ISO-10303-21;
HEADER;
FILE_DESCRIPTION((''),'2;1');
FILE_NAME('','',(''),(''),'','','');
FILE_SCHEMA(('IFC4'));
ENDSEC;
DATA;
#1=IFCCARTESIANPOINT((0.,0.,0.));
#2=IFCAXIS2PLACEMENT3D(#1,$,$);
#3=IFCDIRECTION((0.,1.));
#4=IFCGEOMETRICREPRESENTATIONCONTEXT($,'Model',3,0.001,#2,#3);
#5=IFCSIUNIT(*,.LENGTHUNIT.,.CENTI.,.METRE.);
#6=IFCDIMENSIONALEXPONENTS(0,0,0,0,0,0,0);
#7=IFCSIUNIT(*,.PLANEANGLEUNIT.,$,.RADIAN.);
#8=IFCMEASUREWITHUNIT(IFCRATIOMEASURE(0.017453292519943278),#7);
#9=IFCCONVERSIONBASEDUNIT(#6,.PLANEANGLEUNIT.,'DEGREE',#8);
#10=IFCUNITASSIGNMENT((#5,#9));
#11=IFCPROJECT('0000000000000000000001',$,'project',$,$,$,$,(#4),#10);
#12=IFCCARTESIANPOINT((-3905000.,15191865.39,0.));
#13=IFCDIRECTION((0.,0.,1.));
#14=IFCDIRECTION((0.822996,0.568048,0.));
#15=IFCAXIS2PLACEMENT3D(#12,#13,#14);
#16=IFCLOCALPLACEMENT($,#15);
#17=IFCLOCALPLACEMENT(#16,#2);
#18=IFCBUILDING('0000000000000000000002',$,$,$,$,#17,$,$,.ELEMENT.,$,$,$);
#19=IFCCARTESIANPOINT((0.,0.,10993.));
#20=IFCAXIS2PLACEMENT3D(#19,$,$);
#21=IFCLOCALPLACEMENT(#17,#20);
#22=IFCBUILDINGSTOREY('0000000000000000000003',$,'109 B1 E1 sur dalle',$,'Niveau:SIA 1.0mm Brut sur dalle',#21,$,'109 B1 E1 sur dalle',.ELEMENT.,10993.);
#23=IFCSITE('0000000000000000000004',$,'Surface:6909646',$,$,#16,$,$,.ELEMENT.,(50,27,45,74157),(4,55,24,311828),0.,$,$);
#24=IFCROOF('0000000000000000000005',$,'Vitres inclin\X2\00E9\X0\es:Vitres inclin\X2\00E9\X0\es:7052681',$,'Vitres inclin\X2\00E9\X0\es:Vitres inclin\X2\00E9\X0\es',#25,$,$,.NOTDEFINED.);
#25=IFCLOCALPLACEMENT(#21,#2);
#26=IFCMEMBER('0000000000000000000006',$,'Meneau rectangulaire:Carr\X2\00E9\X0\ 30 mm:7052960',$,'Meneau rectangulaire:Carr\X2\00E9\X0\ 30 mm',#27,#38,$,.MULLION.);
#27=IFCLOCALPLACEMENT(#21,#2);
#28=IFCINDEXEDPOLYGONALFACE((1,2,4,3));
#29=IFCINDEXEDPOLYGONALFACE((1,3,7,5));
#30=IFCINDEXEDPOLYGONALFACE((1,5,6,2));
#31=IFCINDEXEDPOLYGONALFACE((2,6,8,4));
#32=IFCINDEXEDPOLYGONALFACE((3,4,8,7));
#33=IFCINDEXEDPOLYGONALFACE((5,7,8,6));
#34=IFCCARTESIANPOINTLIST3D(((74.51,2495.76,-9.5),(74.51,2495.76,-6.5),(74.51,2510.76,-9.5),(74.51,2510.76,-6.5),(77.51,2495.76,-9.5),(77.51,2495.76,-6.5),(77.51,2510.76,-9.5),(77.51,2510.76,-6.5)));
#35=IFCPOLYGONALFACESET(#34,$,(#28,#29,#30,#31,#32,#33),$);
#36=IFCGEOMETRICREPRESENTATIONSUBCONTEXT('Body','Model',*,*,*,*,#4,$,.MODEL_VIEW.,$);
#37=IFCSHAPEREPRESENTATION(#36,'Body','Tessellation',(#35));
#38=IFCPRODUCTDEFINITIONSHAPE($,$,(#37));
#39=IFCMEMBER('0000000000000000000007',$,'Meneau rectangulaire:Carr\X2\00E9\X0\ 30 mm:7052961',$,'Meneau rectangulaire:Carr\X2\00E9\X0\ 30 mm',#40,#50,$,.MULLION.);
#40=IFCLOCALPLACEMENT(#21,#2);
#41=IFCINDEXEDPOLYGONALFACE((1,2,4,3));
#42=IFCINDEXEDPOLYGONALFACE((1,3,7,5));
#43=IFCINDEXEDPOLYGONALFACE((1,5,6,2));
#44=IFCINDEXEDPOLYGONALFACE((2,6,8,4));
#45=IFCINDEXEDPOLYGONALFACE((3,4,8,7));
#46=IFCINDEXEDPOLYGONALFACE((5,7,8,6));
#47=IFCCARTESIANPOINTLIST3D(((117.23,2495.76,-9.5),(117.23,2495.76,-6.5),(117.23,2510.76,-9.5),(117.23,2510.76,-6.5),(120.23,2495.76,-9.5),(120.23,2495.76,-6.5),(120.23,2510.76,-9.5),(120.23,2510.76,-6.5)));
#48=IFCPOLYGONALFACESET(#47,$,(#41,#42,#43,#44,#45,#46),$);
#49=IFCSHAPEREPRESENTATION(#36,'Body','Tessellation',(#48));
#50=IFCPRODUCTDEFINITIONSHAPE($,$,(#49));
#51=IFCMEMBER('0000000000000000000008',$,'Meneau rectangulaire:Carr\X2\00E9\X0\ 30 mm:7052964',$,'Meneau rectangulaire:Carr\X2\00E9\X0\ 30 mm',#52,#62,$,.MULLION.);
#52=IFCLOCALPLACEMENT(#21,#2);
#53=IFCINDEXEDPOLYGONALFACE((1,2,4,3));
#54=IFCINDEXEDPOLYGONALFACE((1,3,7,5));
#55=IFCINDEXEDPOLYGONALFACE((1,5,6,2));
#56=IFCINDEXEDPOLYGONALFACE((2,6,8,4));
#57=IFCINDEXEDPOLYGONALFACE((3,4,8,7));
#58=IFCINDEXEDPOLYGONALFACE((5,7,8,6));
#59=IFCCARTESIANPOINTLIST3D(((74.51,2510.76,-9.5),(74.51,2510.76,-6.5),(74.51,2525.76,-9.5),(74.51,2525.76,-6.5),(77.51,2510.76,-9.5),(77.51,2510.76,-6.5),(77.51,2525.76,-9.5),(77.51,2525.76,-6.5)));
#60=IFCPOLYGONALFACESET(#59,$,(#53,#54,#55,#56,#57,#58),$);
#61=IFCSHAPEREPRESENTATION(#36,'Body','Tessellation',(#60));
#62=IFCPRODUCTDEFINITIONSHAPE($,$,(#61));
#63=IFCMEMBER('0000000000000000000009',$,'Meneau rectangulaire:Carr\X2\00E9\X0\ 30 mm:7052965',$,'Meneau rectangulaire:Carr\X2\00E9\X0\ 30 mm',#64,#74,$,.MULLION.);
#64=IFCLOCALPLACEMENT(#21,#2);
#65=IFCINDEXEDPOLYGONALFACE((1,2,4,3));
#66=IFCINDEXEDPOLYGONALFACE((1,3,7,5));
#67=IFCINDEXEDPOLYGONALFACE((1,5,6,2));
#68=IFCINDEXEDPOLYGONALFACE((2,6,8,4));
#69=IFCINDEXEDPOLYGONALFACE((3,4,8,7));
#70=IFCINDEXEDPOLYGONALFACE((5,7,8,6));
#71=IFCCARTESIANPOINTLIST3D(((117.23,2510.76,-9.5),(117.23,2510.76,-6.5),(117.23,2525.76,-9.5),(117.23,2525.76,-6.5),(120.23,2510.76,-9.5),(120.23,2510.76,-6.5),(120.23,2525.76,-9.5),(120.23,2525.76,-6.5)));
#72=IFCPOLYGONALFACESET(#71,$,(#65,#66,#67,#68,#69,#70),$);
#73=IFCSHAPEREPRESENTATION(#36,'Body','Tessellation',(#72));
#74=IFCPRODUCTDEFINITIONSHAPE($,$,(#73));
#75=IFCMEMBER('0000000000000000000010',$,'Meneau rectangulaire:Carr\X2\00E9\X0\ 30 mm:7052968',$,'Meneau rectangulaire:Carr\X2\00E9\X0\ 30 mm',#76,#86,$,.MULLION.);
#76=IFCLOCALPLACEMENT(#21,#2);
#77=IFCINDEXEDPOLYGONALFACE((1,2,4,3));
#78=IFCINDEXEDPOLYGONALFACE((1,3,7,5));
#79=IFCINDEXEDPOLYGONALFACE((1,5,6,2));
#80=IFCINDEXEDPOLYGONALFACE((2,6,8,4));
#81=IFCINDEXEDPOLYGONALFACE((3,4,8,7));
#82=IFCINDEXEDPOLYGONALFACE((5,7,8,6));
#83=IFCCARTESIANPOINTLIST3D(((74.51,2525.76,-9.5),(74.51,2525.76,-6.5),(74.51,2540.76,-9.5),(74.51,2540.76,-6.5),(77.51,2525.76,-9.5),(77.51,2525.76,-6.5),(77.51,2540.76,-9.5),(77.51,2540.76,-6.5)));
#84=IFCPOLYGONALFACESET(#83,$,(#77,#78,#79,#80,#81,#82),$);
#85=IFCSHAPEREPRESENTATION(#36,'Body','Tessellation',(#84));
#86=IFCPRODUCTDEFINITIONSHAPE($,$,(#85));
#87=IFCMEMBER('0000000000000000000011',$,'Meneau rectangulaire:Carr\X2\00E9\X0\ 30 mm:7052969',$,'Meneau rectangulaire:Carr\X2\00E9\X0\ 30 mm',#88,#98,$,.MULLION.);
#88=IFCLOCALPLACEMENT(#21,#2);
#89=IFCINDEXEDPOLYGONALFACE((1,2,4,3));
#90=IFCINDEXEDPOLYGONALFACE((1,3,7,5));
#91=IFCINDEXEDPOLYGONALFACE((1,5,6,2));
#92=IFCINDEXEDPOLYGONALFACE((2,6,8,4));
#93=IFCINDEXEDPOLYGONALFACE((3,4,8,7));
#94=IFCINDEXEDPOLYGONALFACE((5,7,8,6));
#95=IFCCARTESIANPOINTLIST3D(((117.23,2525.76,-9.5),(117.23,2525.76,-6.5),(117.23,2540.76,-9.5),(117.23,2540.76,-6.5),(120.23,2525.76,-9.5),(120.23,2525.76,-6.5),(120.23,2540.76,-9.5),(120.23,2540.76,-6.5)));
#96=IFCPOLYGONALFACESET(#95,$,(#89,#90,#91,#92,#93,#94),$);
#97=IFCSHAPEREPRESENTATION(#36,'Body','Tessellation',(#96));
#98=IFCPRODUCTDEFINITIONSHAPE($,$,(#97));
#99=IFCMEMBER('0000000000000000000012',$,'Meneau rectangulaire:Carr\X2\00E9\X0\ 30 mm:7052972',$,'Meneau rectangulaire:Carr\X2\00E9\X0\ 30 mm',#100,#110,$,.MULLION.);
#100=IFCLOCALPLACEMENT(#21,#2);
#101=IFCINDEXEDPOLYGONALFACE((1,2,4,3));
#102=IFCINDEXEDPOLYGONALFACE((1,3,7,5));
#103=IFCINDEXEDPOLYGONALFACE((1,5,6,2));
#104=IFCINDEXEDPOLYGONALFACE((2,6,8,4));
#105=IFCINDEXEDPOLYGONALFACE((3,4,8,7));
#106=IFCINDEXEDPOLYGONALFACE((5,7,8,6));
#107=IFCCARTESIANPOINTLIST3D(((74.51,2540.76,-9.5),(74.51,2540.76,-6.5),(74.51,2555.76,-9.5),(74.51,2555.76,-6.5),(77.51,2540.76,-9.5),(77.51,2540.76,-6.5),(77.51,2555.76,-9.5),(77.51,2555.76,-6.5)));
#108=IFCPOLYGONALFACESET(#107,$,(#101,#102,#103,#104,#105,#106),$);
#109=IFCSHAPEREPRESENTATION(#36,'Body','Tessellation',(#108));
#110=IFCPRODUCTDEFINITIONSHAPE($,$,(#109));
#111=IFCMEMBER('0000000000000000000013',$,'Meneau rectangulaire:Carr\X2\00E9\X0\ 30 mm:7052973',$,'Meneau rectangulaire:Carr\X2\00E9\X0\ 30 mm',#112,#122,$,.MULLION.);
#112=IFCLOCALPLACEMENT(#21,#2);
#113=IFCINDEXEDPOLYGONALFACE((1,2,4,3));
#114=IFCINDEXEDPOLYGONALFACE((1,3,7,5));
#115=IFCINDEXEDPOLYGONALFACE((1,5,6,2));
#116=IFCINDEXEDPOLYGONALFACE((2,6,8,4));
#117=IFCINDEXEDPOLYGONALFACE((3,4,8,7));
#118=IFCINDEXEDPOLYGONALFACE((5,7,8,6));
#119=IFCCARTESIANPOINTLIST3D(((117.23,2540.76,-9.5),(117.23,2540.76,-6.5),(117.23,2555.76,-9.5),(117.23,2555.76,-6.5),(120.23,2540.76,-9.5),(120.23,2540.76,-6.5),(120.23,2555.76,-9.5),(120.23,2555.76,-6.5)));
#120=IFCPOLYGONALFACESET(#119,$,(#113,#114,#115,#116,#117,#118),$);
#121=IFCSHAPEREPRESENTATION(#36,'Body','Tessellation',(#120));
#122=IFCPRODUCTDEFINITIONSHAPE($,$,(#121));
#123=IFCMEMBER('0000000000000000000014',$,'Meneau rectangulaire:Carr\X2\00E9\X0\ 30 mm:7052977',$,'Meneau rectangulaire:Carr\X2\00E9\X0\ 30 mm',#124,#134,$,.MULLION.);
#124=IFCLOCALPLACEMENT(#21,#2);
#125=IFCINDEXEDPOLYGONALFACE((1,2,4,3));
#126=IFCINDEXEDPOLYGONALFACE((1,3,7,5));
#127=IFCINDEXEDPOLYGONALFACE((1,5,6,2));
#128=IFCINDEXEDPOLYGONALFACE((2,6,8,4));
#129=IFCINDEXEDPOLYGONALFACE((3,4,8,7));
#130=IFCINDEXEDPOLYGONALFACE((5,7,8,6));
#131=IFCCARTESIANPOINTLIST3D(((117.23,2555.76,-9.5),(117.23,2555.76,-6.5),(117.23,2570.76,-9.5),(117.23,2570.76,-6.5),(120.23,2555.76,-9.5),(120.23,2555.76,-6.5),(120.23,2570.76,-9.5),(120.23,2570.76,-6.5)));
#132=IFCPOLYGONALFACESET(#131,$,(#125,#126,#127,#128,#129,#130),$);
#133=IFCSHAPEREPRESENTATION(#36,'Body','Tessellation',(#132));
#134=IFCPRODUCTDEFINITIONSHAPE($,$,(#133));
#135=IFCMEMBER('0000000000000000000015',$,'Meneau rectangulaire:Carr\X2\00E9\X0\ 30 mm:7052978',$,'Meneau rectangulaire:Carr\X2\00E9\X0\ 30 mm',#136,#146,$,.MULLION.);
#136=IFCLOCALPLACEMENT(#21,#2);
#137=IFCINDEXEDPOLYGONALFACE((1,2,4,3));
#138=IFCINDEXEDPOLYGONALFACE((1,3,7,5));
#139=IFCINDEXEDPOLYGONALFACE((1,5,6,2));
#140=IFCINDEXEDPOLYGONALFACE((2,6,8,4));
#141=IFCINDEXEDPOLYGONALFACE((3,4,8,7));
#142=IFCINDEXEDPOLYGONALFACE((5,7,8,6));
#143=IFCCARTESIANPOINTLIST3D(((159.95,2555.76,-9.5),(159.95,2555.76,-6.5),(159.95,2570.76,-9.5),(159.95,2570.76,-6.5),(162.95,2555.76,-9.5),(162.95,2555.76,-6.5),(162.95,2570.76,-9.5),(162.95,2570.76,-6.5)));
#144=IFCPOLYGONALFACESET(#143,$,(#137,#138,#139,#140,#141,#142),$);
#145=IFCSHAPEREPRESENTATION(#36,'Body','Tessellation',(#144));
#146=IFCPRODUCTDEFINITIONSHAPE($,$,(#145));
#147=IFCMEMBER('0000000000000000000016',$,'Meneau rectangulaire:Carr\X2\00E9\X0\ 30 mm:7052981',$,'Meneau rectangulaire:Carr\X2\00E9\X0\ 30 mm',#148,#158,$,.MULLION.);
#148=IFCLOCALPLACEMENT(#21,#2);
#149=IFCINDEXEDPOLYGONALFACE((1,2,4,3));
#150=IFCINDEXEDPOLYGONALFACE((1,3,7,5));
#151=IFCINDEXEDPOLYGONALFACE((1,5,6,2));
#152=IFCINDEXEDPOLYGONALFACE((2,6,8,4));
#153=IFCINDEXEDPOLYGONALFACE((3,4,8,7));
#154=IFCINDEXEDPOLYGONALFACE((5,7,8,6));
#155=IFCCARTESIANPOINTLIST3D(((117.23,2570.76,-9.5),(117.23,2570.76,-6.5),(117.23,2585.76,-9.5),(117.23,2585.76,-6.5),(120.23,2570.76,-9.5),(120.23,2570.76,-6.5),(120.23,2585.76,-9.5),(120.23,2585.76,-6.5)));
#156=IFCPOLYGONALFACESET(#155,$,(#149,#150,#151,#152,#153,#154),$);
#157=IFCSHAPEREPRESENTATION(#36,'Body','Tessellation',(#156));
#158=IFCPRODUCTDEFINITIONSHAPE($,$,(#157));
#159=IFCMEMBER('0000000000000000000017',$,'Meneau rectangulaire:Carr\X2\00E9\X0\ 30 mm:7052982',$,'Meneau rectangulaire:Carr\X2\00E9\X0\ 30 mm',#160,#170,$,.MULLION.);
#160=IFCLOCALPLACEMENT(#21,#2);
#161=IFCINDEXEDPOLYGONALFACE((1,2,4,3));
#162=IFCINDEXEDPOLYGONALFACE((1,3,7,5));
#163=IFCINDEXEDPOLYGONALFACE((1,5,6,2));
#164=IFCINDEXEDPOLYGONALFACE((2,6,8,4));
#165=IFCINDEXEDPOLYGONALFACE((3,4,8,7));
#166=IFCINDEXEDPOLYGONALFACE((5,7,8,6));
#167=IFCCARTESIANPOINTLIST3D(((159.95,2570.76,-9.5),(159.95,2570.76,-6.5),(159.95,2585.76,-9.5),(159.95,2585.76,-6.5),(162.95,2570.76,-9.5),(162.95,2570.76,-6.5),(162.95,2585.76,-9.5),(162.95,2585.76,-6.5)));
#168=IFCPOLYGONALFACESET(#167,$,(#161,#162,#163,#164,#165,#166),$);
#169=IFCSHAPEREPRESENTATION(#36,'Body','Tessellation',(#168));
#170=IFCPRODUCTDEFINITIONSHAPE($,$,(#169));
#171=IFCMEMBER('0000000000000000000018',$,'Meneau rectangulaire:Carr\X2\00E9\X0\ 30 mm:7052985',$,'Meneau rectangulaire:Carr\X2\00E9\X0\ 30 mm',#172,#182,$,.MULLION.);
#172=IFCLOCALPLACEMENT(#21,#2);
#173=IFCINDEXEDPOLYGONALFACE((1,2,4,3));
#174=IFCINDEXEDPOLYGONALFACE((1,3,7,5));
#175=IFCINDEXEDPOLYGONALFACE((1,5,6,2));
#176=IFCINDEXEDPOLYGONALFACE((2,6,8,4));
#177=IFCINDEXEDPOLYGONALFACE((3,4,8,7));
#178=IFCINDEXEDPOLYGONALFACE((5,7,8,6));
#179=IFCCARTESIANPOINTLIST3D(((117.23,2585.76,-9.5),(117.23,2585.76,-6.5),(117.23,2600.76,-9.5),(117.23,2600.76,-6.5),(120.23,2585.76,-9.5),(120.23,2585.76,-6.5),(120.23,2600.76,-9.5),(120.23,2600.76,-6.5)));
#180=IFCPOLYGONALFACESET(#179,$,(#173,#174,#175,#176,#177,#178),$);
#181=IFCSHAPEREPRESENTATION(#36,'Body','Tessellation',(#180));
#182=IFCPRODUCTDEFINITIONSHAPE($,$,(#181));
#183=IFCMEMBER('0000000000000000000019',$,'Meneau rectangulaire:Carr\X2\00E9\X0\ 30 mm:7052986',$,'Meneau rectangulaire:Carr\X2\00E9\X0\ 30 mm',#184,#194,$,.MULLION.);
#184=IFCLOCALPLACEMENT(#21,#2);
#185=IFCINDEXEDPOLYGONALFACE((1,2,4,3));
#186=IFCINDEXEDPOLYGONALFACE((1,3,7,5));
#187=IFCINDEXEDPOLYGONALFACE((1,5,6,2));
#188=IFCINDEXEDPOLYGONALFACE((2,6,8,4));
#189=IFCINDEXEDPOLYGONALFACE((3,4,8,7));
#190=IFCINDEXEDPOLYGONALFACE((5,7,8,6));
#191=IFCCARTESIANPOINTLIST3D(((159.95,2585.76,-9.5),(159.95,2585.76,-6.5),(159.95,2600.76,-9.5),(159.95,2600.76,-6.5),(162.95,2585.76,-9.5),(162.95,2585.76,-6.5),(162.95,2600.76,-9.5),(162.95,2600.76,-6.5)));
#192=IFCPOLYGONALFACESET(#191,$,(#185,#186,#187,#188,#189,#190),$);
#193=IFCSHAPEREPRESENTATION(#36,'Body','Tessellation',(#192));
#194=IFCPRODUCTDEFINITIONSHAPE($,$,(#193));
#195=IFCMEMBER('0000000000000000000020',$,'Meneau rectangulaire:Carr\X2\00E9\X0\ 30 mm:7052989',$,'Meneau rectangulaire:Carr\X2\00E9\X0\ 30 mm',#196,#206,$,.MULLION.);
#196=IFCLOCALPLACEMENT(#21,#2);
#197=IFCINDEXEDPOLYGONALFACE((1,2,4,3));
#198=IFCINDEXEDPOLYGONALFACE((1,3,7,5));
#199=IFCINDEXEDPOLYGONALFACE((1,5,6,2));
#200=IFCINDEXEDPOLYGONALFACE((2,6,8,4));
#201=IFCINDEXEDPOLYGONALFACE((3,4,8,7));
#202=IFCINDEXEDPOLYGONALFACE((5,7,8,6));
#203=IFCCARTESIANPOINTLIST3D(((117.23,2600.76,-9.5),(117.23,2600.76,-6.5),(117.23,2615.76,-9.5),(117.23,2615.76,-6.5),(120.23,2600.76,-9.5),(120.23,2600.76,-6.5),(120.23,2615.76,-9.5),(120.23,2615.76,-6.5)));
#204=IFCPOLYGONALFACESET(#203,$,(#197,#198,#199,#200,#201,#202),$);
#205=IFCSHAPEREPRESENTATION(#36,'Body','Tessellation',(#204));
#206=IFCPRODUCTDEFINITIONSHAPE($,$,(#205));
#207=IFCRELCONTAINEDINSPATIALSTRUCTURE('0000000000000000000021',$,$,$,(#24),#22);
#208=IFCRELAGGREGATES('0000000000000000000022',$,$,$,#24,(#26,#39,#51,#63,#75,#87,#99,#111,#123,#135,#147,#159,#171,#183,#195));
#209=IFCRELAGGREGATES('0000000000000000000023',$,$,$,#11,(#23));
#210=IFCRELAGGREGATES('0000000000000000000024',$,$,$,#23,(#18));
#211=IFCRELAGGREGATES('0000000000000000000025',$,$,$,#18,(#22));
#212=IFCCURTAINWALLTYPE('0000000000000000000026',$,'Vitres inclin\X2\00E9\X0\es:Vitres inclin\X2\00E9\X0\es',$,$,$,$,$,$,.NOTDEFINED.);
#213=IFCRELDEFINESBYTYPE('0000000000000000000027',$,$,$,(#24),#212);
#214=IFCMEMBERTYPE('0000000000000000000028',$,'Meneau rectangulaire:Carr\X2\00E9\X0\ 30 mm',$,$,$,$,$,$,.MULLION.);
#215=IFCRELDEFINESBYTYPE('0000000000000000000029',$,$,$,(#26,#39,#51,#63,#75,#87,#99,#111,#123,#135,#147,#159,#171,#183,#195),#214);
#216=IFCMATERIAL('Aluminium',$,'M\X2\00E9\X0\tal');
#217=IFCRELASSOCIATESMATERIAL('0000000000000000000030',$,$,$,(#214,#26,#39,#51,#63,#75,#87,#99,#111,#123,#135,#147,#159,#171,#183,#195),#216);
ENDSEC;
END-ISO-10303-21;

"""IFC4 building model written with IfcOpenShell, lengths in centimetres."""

from ifc_helpers import new_model, entity, si_unit, converted_unit, direction, frame, origin, place, context, subcontext, project, spatial, indexed_curve, outline, extrude, source, transform, mapped, material, type_object, type_shapes, element, aggregate, save


model = new_model("IFC4")

# Units and contexts
model_context = context("Model", 3, precision=0.001, world=origin(), true_north=direction((0.0, 1.0)))
body_context = subcontext(model_context, "Body", "Model", "MODEL_VIEW")
ifc_project = project(units=[si_unit("LENGTHUNIT", "METRE", prefix="CENTI"), converted_unit("PLANEANGLEUNIT", "DEGREE", entity("IfcRatioMeasure", 0.017453292519943278), si_unit("PLANEANGLEUNIT", "RADIAN"), dimensions=[0, 0, 0, 0, 0, 0, 0])], contexts=[model_context])

# Site, building, storey
site_placement = place(None, frame((-3905000.0, 15191865.39, 0.0), z_axis=(0.0, 0.0, 1.0), x_axis=(0.822996, 0.568048, 0.0)))
site = spatial("IfcSite", under=ifc_project, at=site_placement, Name="Surface:6909646", CompositionType="ELEMENT", RefLatitude=(50, 27, 45, 74157), RefLongitude=(4, 55, 24, 311828), RefElevation=0.0)
building_placement = place(site_placement, origin())
building = spatial("IfcBuilding", under=site, at=building_placement, CompositionType="ELEMENT")
storey_placement = place(building_placement, frame((0.0, 0.0, 10993.0)))
storey = spatial("IfcBuildingStorey", under=building, at=storey_placement, Name="109 B1 E1 sur dalle", ObjectType="Niveau:SIA 1.0mm Brut sur dalle", LongName="109 B1 E1 sur dalle", CompositionType="ELEMENT", Elevation=10993.0)

# Roof, members
curtain_wall_type = type_object("IfcCurtainWallType", Name="Vitres inclinées:Vitres inclinées", PredefinedType="NOTDEFINED")
roof_placement = place(storey_placement, frame((0.0, 0.0, -10993.0)))
roof = element("IfcRoof", 1, at=roof_placement, inside=storey, type_object=curtain_wall_type, Name="Vitres inclinées:Vitres inclinées:7052681", ObjectType="Vitres inclinées:Vitres inclinées", PredefinedType="NOTDEFINED")
ifc_material = material(Name="Aluminium", Category="Métal")
member_type_1 = type_object("IfcMemberType", Name="Meneau rectangulaire:Carré 30 mm", PredefinedType="MULLION", material=ifc_material)
shared_shape_1 = source(origin(), body_context, "Body", "SweptSolid", [
    extrude(outline(indexed_curve([(-1.5, -1.5), (1.5, -1.5), (1.5, 1.5), (-1.5, 1.5), (-1.5, -1.5)], self_intersect=False)), frame((0.0, 0.0, -15.0), z_axis=(0.0, 0.0, 1.0), x_axis=(0.0, -1.0, 0.0)), (0.0, 0.0, 1.0), 15.0),
])
type_shapes(member_type_1, [shared_shape_1])
member_1_placement = place(roof_placement, frame((76.01, 2510.76, 10985.0), z_axis=(0.0, 1.0, 0.0), x_axis=(1.0, 0.0, 0.0)))
member_1 = element("IfcMember", 2, at=member_1_placement, type_object=member_type_1, material=ifc_material, Name="Meneau rectangulaire:Carré 30 mm:7052960", ObjectType="Meneau rectangulaire:Carré 30 mm", PredefinedType="MULLION", context=body_context, shape_type="MappedRepresentation", body=[
    mapped(shared_shape_1, transform((0.0, 0.0, 0.0), scale=1.0)),
])
member_2_placement = place(roof_placement, frame((118.73, 2510.76, 10985.0), z_axis=(0.0, 1.0, 0.0), x_axis=(1.0, 0.0, 0.0)))
member_2 = element("IfcMember", 3, at=member_2_placement, type_object=member_type_1, material=ifc_material, Name="Meneau rectangulaire:Carré 30 mm:7052961", ObjectType="Meneau rectangulaire:Carré 30 mm", PredefinedType="MULLION", context=body_context, shape_type="MappedRepresentation", body=[
    mapped(shared_shape_1, transform((0.0, 0.0, 0.0), scale=1.0)),
])
member_3_placement = place(roof_placement, frame((76.01, 2525.76, 10985.0), z_axis=(0.0, 1.0, 0.0), x_axis=(1.0, 0.0, 0.0)))
member_3 = element("IfcMember", 4, at=member_3_placement, type_object=member_type_1, material=ifc_material, Name="Meneau rectangulaire:Carré 30 mm:7052964", ObjectType="Meneau rectangulaire:Carré 30 mm", PredefinedType="MULLION", context=body_context, shape_type="MappedRepresentation", body=[
    mapped(shared_shape_1, transform((0.0, 0.0, 0.0), scale=1.0)),
])
member_4_placement = place(roof_placement, frame((118.73, 2525.76, 10985.0), z_axis=(0.0, 1.0, 0.0), x_axis=(1.0, 0.0, 0.0)))
member_4 = element("IfcMember", 5, at=member_4_placement, type_object=member_type_1, material=ifc_material, Name="Meneau rectangulaire:Carré 30 mm:7052965", ObjectType="Meneau rectangulaire:Carré 30 mm", PredefinedType="MULLION", context=body_context, shape_type="MappedRepresentation", body=[
    mapped(shared_shape_1, transform((0.0, 0.0, 0.0), scale=1.0)),
])
member_5_placement = place(roof_placement, frame((76.01, 2540.76, 10985.0), z_axis=(0.0, 1.0, 0.0), x_axis=(1.0, 0.0, 0.0)))
member_5 = element("IfcMember", 6, at=member_5_placement, type_object=member_type_1, material=ifc_material, Name="Meneau rectangulaire:Carré 30 mm:7052968", ObjectType="Meneau rectangulaire:Carré 30 mm", PredefinedType="MULLION", context=body_context, shape_type="MappedRepresentation", body=[
    mapped(shared_shape_1, transform((0.0, 0.0, 0.0), scale=1.0)),
])
member_6_placement = place(roof_placement, frame((118.73, 2540.76, 10985.0), z_axis=(0.0, 1.0, 0.0), x_axis=(1.0, 0.0, 0.0)))
member_6 = element("IfcMember", 7, at=member_6_placement, type_object=member_type_1, material=ifc_material, Name="Meneau rectangulaire:Carré 30 mm:7052969", ObjectType="Meneau rectangulaire:Carré 30 mm", PredefinedType="MULLION", context=body_context, shape_type="MappedRepresentation", body=[
    mapped(shared_shape_1, transform((0.0, 0.0, 0.0), scale=1.0)),
])
member_7_placement = place(roof_placement, frame((76.01, 2555.76, 10985.0), z_axis=(0.0, 1.0, 0.0), x_axis=(1.0, 0.0, 0.0)))
member_7 = element("IfcMember", 8, at=member_7_placement, type_object=member_type_1, material=ifc_material, Name="Meneau rectangulaire:Carré 30 mm:7052972", ObjectType="Meneau rectangulaire:Carré 30 mm", PredefinedType="MULLION", context=body_context, shape_type="MappedRepresentation", body=[
    mapped(shared_shape_1, transform((0.0, 0.0, 0.0), scale=1.0)),
])
member_8_placement = place(roof_placement, frame((118.73, 2555.76, 10985.0), z_axis=(0.0, 1.0, 0.0), x_axis=(1.0, 0.0, 0.0)))
member_8 = element("IfcMember", 9, at=member_8_placement, type_object=member_type_1, material=ifc_material, Name="Meneau rectangulaire:Carré 30 mm:7052973", ObjectType="Meneau rectangulaire:Carré 30 mm", PredefinedType="MULLION", context=body_context, shape_type="MappedRepresentation", body=[
    mapped(shared_shape_1, transform((0.0, 0.0, 0.0), scale=1.0)),
])
member_9_placement = place(roof_placement, frame((118.73, 2570.76, 10985.0), z_axis=(0.0, 1.0, 0.0), x_axis=(1.0, 0.0, 0.0)))
member_9 = element("IfcMember", 10, at=member_9_placement, type_object=member_type_1, material=ifc_material, Name="Meneau rectangulaire:Carré 30 mm:7052977", ObjectType="Meneau rectangulaire:Carré 30 mm", PredefinedType="MULLION", context=body_context, shape_type="MappedRepresentation", body=[
    mapped(shared_shape_1, transform((0.0, 0.0, 0.0), scale=1.0)),
])
member_10_placement = place(roof_placement, frame((161.45, 2570.76, 10985.0), z_axis=(0.0, 1.0, 0.0), x_axis=(1.0, 0.0, 0.0)))
member_10 = element("IfcMember", 11, at=member_10_placement, type_object=member_type_1, material=ifc_material, Name="Meneau rectangulaire:Carré 30 mm:7052978", ObjectType="Meneau rectangulaire:Carré 30 mm", PredefinedType="MULLION", context=body_context, shape_type="MappedRepresentation", body=[
    mapped(shared_shape_1, transform((0.0, 0.0, 0.0), scale=1.0)),
])
member_11_placement = place(roof_placement, frame((118.73, 2585.76, 10985.0), z_axis=(0.0, 1.0, 0.0), x_axis=(1.0, 0.0, 0.0)))
member_11 = element("IfcMember", 12, at=member_11_placement, type_object=member_type_1, material=ifc_material, Name="Meneau rectangulaire:Carré 30 mm:7052981", ObjectType="Meneau rectangulaire:Carré 30 mm", PredefinedType="MULLION", context=body_context, shape_type="MappedRepresentation", body=[
    mapped(shared_shape_1, transform((0.0, 0.0, 0.0), scale=1.0)),
])
member_12_placement = place(roof_placement, frame((161.45, 2585.76, 10985.0), z_axis=(0.0, 1.0, 0.0), x_axis=(1.0, 0.0, 0.0)))
member_12 = element("IfcMember", 13, at=member_12_placement, type_object=member_type_1, material=ifc_material, Name="Meneau rectangulaire:Carré 30 mm:7052982", ObjectType="Meneau rectangulaire:Carré 30 mm", PredefinedType="MULLION", context=body_context, shape_type="MappedRepresentation", body=[
    mapped(shared_shape_1, transform((0.0, 0.0, 0.0), scale=1.0)),
])
member_13_placement = place(roof_placement, frame((118.73, 2600.76, 10985.0), z_axis=(0.0, 1.0, 0.0), x_axis=(1.0, 0.0, 0.0)))
member_13 = element("IfcMember", 14, at=member_13_placement, type_object=member_type_1, material=ifc_material, Name="Meneau rectangulaire:Carré 30 mm:7052985", ObjectType="Meneau rectangulaire:Carré 30 mm", PredefinedType="MULLION", context=body_context, shape_type="MappedRepresentation", body=[
    mapped(shared_shape_1, transform((0.0, 0.0, 0.0), scale=1.0)),
])
member_14_placement = place(roof_placement, frame((161.45, 2600.76, 10985.0), z_axis=(0.0, 1.0, 0.0), x_axis=(1.0, 0.0, 0.0)))
member_14 = element("IfcMember", 15, at=member_14_placement, type_object=member_type_1, material=ifc_material, Name="Meneau rectangulaire:Carré 30 mm:7052986", ObjectType="Meneau rectangulaire:Carré 30 mm", PredefinedType="MULLION", context=body_context, shape_type="MappedRepresentation", body=[
    mapped(shared_shape_1, transform((0.0, 0.0, 0.0), scale=1.0)),
])
member_15_placement = place(roof_placement, frame((118.73, 2615.76, 10985.0), z_axis=(0.0, 1.0, 0.0), x_axis=(1.0, 0.0, 0.0)))
member_15 = element("IfcMember", 16, at=member_15_placement, type_object=member_type_1, material=ifc_material, Name="Meneau rectangulaire:Carré 30 mm:7052989", ObjectType="Meneau rectangulaire:Carré 30 mm", PredefinedType="MULLION", context=body_context, shape_type="MappedRepresentation", body=[
    mapped(shared_shape_1, transform((0.0, 0.0, 0.0), scale=1.0)),
])
aggregate(roof, [member_1, member_2, member_3, member_4, member_5, member_6, member_7, member_8, member_9, member_10, member_11, member_12, member_13, member_14, member_15])

save(model, "model.ifc")
